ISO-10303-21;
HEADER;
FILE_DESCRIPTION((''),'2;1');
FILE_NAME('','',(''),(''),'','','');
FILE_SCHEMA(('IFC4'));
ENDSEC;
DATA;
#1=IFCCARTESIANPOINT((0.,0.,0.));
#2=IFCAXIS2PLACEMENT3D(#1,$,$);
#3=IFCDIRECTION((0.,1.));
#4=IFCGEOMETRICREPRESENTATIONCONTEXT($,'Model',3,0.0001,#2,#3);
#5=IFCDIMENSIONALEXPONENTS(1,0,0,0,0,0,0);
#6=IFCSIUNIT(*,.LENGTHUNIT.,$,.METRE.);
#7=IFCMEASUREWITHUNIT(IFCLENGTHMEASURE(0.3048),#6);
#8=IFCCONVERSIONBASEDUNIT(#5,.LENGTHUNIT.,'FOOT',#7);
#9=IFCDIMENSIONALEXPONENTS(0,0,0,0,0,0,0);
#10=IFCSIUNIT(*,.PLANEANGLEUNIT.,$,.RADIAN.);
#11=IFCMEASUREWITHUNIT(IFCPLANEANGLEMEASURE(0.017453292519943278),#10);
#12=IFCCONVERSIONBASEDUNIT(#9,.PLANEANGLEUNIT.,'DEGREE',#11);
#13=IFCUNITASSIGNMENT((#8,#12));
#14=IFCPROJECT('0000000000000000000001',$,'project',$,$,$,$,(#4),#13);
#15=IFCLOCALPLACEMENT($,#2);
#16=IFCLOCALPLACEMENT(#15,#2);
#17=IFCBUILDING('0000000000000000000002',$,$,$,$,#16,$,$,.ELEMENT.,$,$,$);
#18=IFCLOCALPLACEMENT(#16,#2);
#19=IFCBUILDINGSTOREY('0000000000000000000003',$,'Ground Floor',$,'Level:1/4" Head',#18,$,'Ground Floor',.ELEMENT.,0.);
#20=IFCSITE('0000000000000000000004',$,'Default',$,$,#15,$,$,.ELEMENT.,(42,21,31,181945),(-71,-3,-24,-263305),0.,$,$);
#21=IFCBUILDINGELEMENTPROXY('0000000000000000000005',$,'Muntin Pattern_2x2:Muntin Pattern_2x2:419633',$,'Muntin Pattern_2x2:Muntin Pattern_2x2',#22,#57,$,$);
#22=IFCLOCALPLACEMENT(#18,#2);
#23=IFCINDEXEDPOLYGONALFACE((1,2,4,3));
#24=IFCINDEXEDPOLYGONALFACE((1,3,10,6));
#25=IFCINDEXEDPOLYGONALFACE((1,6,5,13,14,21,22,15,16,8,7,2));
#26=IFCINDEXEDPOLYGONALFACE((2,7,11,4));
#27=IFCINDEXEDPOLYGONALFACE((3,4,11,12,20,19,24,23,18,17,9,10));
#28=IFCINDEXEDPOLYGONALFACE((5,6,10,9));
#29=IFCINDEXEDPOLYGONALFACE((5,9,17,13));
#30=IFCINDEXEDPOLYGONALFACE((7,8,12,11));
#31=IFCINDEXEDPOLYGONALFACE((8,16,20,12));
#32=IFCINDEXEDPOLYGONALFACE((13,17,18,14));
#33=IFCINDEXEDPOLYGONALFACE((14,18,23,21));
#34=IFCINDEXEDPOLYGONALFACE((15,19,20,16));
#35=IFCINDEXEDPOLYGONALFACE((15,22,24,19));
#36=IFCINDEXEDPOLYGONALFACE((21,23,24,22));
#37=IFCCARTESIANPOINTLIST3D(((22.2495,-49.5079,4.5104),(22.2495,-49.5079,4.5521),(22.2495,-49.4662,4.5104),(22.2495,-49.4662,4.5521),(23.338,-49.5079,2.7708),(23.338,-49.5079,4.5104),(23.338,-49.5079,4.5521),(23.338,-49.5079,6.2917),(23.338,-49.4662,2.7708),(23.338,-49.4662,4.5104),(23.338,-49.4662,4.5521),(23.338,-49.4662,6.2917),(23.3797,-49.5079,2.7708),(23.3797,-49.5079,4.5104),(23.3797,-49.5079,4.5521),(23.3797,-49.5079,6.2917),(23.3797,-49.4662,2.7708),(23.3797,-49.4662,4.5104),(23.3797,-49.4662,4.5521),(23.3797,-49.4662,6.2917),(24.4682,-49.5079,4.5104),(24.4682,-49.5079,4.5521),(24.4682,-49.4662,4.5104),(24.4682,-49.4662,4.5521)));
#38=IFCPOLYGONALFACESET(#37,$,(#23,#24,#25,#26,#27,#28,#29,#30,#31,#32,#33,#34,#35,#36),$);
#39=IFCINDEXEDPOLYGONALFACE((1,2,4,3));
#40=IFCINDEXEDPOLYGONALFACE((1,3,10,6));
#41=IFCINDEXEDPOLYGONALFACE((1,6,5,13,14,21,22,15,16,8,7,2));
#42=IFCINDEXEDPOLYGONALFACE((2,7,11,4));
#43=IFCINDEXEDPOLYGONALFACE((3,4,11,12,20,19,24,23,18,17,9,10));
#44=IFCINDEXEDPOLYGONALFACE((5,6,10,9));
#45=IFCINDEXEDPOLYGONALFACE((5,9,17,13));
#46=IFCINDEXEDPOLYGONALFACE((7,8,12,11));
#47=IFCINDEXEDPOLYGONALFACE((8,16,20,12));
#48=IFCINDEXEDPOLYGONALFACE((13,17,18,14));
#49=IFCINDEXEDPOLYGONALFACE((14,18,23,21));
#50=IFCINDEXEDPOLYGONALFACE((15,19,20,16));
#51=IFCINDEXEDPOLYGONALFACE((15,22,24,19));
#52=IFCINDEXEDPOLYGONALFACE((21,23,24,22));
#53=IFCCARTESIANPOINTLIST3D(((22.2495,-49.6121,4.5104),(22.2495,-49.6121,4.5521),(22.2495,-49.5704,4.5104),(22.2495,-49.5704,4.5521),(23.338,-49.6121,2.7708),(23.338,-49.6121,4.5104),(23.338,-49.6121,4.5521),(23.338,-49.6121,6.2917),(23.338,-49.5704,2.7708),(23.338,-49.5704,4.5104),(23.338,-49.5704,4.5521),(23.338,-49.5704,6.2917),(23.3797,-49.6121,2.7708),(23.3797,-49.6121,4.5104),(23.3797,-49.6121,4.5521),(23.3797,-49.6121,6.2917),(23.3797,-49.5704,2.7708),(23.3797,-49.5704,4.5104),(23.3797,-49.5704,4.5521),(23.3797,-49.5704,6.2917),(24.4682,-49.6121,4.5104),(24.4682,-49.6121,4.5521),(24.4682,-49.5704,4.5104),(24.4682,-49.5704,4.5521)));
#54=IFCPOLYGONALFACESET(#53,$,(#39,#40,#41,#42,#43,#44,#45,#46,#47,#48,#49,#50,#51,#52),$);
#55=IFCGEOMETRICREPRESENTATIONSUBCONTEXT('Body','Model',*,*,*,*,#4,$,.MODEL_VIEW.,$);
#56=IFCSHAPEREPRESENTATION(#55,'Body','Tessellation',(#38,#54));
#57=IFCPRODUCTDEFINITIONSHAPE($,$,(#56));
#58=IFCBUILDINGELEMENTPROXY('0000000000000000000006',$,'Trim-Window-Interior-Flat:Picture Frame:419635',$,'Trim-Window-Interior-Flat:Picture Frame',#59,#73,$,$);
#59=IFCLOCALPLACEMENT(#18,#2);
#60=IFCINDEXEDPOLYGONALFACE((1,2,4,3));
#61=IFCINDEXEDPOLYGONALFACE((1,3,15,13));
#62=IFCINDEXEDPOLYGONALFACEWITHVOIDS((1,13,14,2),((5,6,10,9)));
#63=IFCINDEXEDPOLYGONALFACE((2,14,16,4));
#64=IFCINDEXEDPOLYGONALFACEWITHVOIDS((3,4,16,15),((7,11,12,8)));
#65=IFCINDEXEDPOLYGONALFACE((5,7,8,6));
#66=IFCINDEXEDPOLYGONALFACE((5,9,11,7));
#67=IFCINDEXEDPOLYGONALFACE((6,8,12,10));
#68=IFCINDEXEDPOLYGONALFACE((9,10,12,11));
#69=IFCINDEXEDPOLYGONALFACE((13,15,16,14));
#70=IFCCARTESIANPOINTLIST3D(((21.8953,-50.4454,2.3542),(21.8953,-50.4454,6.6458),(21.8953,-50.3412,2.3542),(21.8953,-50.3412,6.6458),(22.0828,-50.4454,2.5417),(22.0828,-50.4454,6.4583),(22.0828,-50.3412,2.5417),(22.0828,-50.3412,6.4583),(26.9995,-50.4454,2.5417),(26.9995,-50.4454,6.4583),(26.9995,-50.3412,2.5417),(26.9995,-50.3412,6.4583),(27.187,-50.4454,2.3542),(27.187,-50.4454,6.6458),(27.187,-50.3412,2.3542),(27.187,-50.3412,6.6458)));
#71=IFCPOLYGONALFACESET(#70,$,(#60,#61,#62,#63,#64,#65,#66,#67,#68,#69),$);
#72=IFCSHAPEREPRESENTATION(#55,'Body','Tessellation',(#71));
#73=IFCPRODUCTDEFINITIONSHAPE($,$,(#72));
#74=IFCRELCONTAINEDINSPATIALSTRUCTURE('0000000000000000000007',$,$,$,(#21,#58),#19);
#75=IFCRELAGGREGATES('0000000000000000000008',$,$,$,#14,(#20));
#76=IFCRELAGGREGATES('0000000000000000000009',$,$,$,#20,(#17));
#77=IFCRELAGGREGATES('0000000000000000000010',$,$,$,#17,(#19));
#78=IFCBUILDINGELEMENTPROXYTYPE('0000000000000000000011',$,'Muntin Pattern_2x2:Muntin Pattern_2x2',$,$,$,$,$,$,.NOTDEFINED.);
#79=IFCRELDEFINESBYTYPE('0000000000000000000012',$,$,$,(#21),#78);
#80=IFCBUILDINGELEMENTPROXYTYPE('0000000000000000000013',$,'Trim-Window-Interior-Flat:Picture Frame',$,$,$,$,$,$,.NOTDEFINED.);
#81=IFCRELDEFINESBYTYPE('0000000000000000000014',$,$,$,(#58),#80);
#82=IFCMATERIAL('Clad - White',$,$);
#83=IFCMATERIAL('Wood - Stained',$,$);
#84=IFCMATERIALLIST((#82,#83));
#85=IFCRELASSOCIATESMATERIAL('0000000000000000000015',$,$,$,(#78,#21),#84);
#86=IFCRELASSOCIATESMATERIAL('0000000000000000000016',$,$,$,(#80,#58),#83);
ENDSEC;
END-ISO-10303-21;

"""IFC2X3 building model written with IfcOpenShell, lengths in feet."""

from ifc_helpers import new_model, entity, si_unit, converted_unit, direction, frame, origin, place, context, subcontext, project, spatial, polyline, outline, extrude, source, transform, mapped, material, material_list, type_object, type_shapes, element, save


model = new_model("IFC2X3")

# Units and contexts
model_context = context("Model", 3, precision=0.0001, world=origin(), true_north=direction((0.0, 1.0)))
body_context = subcontext(model_context, "Body", "Model", "MODEL_VIEW")
ifc_project = project(units=[converted_unit("LENGTHUNIT", "FOOT", entity("IfcLengthMeasure", 0.3048), si_unit("LENGTHUNIT", "METRE"), dimensions=[1, 0, 0, 0, 0, 0, 0]), converted_unit("PLANEANGLEUNIT", "DEGREE", entity("IfcPlaneAngleMeasure", 0.017453292519943278), si_unit("PLANEANGLEUNIT", "RADIAN"), dimensions=[0, 0, 0, 0, 0, 0, 0])], contexts=[model_context])

# Site, building, storey
site_placement = place(None, origin())
site = spatial("IfcSite", under=ifc_project, at=site_placement, Name="Default", CompositionType="ELEMENT", RefLatitude=(42, 21, 31, 181945), RefLongitude=(-71, -3, -24, -263305), RefElevation=0.0)
building_placement = place(site_placement, origin())
building = spatial("IfcBuilding", under=site, at=building_placement, CompositionType="ELEMENT")
storey_placement = place(building_placement, origin())
storey = spatial("IfcBuildingStorey", under=building, at=storey_placement, Name="Ground Floor", ObjectType="Level:1/4\" Head", LongName="Ground Floor", CompositionType="ELEMENT", Elevation=0.0)

# Building element proxies
ifc_material_1 = material(Name="Clad - White")
ifc_material_2 = material(Name="Wood - Stained")
ifc_material_list_1 = material_list([ifc_material_1, ifc_material_2])
building_element_proxy_type_1 = type_object("IfcBuildingElementProxyType", Name="Muntin Pattern_2x2:Muntin Pattern_2x2", PredefinedType="NOTDEFINED", material=ifc_material_list_1)
shared_shape_1 = source(origin(), body_context, "Body", "SweptSolid", [
    extrude(outline(polyline([(0.0208, -0.0208), (1.7604, -0.0208), (1.7604, 0.0208), (0.0208, 0.0208), (0.0208, 1.1094), (-0.0208, 1.1094), (-0.0208, 0.0208), (-1.7604, 0.0208), (-1.7604, -0.0208), (-0.0208, -0.0208), (-0.0208, -1.1094), (0.0208, -1.1094), (0.0208, -0.0208)])), frame((0.0, 0.0313, 1.7604), z_axis=(0.0, 1.0, 0.0), x_axis=(0.0, 0.0, 1.0)), (0.0, 0.0, 1.0), 0.0417),
    extrude(outline(polyline([(0.0208, -0.0208), (1.7604, -0.0208), (1.7604, 0.0208), (0.0208, 0.0208), (0.0208, 1.1094), (-0.0208, 1.1094), (-0.0208, 0.0208), (-1.7604, 0.0208), (-1.7604, -0.0208), (-0.0208, -0.0208), (-0.0208, -1.1094), (0.0208, -1.1094), (0.0208, -0.0208)])), frame((0.0, -0.0729, 1.7604), z_axis=(0.0, 1.0, 0.0), x_axis=(0.0, 0.0, 1.0)), (0.0, 0.0, 1.0), 0.0417),
])
type_shapes(building_element_proxy_type_1, [shared_shape_1])
for number, where, name in (
    (1, (23.3589, -49.5392, 2.7708), "Muntin Pattern_2x2:Muntin Pattern_2x2:419633"),
):
    element("IfcBuildingElementProxy", number, at=place(storey_placement, frame(where)), inside=storey, type_object=building_element_proxy_type_1, material=ifc_material_list_1, Name=name, ObjectType="Muntin Pattern_2x2:Muntin Pattern_2x2", context=body_context, shape_type="MappedRepresentation", body=[
        mapped(shared_shape_1, transform((0.0, 0.0, 0.0), scale=1.0)),
    ])
building_element_proxy_type_2 = type_object("IfcBuildingElementProxyType", Name="Trim-Window-Interior-Flat:Picture Frame", PredefinedType="NOTDEFINED", material=ifc_material_2)
shared_shape_2 = source(origin(), body_context, "Body", "SweptSolid", [
    extrude(outline(polyline([(-2.6458, -2.1458), (2.6458, -2.1458), (2.6458, 2.1458), (-2.6458, 2.1458), (-2.6458, -2.1458)]), holes=[polyline([(-2.4583, -1.9583), (-2.4583, 1.9583), (2.4583, 1.9583), (2.4583, -1.9583), (-2.4583, -1.9583)])]), frame((0.0, -2.0, 0.0), z_axis=(0.0, 0.0, 1.0), x_axis=(-1.0, 0.0, 0.0)), (0.0, 0.0, 1.0), 0.1042),
])
type_shapes(building_element_proxy_type_2, [shared_shape_2])
proxy_1_placement = place(storey_placement, frame((24.5411, -50.3412, 6.5), z_axis=(0.0, -1.0, 0.0), x_axis=(1.0, 0.0, 0.0)))
element("IfcBuildingElementProxy", 2, at=proxy_1_placement, inside=storey, type_object=building_element_proxy_type_2, material=ifc_material_2, Name="Trim-Window-Interior-Flat:Picture Frame:419635", ObjectType="Trim-Window-Interior-Flat:Picture Frame", context=body_context, shape_type="MappedRepresentation", body=[
    mapped(shared_shape_2, transform((0.0, 0.0, 0.0), scale=1.0)),
])

save(model, "model.ifc")
